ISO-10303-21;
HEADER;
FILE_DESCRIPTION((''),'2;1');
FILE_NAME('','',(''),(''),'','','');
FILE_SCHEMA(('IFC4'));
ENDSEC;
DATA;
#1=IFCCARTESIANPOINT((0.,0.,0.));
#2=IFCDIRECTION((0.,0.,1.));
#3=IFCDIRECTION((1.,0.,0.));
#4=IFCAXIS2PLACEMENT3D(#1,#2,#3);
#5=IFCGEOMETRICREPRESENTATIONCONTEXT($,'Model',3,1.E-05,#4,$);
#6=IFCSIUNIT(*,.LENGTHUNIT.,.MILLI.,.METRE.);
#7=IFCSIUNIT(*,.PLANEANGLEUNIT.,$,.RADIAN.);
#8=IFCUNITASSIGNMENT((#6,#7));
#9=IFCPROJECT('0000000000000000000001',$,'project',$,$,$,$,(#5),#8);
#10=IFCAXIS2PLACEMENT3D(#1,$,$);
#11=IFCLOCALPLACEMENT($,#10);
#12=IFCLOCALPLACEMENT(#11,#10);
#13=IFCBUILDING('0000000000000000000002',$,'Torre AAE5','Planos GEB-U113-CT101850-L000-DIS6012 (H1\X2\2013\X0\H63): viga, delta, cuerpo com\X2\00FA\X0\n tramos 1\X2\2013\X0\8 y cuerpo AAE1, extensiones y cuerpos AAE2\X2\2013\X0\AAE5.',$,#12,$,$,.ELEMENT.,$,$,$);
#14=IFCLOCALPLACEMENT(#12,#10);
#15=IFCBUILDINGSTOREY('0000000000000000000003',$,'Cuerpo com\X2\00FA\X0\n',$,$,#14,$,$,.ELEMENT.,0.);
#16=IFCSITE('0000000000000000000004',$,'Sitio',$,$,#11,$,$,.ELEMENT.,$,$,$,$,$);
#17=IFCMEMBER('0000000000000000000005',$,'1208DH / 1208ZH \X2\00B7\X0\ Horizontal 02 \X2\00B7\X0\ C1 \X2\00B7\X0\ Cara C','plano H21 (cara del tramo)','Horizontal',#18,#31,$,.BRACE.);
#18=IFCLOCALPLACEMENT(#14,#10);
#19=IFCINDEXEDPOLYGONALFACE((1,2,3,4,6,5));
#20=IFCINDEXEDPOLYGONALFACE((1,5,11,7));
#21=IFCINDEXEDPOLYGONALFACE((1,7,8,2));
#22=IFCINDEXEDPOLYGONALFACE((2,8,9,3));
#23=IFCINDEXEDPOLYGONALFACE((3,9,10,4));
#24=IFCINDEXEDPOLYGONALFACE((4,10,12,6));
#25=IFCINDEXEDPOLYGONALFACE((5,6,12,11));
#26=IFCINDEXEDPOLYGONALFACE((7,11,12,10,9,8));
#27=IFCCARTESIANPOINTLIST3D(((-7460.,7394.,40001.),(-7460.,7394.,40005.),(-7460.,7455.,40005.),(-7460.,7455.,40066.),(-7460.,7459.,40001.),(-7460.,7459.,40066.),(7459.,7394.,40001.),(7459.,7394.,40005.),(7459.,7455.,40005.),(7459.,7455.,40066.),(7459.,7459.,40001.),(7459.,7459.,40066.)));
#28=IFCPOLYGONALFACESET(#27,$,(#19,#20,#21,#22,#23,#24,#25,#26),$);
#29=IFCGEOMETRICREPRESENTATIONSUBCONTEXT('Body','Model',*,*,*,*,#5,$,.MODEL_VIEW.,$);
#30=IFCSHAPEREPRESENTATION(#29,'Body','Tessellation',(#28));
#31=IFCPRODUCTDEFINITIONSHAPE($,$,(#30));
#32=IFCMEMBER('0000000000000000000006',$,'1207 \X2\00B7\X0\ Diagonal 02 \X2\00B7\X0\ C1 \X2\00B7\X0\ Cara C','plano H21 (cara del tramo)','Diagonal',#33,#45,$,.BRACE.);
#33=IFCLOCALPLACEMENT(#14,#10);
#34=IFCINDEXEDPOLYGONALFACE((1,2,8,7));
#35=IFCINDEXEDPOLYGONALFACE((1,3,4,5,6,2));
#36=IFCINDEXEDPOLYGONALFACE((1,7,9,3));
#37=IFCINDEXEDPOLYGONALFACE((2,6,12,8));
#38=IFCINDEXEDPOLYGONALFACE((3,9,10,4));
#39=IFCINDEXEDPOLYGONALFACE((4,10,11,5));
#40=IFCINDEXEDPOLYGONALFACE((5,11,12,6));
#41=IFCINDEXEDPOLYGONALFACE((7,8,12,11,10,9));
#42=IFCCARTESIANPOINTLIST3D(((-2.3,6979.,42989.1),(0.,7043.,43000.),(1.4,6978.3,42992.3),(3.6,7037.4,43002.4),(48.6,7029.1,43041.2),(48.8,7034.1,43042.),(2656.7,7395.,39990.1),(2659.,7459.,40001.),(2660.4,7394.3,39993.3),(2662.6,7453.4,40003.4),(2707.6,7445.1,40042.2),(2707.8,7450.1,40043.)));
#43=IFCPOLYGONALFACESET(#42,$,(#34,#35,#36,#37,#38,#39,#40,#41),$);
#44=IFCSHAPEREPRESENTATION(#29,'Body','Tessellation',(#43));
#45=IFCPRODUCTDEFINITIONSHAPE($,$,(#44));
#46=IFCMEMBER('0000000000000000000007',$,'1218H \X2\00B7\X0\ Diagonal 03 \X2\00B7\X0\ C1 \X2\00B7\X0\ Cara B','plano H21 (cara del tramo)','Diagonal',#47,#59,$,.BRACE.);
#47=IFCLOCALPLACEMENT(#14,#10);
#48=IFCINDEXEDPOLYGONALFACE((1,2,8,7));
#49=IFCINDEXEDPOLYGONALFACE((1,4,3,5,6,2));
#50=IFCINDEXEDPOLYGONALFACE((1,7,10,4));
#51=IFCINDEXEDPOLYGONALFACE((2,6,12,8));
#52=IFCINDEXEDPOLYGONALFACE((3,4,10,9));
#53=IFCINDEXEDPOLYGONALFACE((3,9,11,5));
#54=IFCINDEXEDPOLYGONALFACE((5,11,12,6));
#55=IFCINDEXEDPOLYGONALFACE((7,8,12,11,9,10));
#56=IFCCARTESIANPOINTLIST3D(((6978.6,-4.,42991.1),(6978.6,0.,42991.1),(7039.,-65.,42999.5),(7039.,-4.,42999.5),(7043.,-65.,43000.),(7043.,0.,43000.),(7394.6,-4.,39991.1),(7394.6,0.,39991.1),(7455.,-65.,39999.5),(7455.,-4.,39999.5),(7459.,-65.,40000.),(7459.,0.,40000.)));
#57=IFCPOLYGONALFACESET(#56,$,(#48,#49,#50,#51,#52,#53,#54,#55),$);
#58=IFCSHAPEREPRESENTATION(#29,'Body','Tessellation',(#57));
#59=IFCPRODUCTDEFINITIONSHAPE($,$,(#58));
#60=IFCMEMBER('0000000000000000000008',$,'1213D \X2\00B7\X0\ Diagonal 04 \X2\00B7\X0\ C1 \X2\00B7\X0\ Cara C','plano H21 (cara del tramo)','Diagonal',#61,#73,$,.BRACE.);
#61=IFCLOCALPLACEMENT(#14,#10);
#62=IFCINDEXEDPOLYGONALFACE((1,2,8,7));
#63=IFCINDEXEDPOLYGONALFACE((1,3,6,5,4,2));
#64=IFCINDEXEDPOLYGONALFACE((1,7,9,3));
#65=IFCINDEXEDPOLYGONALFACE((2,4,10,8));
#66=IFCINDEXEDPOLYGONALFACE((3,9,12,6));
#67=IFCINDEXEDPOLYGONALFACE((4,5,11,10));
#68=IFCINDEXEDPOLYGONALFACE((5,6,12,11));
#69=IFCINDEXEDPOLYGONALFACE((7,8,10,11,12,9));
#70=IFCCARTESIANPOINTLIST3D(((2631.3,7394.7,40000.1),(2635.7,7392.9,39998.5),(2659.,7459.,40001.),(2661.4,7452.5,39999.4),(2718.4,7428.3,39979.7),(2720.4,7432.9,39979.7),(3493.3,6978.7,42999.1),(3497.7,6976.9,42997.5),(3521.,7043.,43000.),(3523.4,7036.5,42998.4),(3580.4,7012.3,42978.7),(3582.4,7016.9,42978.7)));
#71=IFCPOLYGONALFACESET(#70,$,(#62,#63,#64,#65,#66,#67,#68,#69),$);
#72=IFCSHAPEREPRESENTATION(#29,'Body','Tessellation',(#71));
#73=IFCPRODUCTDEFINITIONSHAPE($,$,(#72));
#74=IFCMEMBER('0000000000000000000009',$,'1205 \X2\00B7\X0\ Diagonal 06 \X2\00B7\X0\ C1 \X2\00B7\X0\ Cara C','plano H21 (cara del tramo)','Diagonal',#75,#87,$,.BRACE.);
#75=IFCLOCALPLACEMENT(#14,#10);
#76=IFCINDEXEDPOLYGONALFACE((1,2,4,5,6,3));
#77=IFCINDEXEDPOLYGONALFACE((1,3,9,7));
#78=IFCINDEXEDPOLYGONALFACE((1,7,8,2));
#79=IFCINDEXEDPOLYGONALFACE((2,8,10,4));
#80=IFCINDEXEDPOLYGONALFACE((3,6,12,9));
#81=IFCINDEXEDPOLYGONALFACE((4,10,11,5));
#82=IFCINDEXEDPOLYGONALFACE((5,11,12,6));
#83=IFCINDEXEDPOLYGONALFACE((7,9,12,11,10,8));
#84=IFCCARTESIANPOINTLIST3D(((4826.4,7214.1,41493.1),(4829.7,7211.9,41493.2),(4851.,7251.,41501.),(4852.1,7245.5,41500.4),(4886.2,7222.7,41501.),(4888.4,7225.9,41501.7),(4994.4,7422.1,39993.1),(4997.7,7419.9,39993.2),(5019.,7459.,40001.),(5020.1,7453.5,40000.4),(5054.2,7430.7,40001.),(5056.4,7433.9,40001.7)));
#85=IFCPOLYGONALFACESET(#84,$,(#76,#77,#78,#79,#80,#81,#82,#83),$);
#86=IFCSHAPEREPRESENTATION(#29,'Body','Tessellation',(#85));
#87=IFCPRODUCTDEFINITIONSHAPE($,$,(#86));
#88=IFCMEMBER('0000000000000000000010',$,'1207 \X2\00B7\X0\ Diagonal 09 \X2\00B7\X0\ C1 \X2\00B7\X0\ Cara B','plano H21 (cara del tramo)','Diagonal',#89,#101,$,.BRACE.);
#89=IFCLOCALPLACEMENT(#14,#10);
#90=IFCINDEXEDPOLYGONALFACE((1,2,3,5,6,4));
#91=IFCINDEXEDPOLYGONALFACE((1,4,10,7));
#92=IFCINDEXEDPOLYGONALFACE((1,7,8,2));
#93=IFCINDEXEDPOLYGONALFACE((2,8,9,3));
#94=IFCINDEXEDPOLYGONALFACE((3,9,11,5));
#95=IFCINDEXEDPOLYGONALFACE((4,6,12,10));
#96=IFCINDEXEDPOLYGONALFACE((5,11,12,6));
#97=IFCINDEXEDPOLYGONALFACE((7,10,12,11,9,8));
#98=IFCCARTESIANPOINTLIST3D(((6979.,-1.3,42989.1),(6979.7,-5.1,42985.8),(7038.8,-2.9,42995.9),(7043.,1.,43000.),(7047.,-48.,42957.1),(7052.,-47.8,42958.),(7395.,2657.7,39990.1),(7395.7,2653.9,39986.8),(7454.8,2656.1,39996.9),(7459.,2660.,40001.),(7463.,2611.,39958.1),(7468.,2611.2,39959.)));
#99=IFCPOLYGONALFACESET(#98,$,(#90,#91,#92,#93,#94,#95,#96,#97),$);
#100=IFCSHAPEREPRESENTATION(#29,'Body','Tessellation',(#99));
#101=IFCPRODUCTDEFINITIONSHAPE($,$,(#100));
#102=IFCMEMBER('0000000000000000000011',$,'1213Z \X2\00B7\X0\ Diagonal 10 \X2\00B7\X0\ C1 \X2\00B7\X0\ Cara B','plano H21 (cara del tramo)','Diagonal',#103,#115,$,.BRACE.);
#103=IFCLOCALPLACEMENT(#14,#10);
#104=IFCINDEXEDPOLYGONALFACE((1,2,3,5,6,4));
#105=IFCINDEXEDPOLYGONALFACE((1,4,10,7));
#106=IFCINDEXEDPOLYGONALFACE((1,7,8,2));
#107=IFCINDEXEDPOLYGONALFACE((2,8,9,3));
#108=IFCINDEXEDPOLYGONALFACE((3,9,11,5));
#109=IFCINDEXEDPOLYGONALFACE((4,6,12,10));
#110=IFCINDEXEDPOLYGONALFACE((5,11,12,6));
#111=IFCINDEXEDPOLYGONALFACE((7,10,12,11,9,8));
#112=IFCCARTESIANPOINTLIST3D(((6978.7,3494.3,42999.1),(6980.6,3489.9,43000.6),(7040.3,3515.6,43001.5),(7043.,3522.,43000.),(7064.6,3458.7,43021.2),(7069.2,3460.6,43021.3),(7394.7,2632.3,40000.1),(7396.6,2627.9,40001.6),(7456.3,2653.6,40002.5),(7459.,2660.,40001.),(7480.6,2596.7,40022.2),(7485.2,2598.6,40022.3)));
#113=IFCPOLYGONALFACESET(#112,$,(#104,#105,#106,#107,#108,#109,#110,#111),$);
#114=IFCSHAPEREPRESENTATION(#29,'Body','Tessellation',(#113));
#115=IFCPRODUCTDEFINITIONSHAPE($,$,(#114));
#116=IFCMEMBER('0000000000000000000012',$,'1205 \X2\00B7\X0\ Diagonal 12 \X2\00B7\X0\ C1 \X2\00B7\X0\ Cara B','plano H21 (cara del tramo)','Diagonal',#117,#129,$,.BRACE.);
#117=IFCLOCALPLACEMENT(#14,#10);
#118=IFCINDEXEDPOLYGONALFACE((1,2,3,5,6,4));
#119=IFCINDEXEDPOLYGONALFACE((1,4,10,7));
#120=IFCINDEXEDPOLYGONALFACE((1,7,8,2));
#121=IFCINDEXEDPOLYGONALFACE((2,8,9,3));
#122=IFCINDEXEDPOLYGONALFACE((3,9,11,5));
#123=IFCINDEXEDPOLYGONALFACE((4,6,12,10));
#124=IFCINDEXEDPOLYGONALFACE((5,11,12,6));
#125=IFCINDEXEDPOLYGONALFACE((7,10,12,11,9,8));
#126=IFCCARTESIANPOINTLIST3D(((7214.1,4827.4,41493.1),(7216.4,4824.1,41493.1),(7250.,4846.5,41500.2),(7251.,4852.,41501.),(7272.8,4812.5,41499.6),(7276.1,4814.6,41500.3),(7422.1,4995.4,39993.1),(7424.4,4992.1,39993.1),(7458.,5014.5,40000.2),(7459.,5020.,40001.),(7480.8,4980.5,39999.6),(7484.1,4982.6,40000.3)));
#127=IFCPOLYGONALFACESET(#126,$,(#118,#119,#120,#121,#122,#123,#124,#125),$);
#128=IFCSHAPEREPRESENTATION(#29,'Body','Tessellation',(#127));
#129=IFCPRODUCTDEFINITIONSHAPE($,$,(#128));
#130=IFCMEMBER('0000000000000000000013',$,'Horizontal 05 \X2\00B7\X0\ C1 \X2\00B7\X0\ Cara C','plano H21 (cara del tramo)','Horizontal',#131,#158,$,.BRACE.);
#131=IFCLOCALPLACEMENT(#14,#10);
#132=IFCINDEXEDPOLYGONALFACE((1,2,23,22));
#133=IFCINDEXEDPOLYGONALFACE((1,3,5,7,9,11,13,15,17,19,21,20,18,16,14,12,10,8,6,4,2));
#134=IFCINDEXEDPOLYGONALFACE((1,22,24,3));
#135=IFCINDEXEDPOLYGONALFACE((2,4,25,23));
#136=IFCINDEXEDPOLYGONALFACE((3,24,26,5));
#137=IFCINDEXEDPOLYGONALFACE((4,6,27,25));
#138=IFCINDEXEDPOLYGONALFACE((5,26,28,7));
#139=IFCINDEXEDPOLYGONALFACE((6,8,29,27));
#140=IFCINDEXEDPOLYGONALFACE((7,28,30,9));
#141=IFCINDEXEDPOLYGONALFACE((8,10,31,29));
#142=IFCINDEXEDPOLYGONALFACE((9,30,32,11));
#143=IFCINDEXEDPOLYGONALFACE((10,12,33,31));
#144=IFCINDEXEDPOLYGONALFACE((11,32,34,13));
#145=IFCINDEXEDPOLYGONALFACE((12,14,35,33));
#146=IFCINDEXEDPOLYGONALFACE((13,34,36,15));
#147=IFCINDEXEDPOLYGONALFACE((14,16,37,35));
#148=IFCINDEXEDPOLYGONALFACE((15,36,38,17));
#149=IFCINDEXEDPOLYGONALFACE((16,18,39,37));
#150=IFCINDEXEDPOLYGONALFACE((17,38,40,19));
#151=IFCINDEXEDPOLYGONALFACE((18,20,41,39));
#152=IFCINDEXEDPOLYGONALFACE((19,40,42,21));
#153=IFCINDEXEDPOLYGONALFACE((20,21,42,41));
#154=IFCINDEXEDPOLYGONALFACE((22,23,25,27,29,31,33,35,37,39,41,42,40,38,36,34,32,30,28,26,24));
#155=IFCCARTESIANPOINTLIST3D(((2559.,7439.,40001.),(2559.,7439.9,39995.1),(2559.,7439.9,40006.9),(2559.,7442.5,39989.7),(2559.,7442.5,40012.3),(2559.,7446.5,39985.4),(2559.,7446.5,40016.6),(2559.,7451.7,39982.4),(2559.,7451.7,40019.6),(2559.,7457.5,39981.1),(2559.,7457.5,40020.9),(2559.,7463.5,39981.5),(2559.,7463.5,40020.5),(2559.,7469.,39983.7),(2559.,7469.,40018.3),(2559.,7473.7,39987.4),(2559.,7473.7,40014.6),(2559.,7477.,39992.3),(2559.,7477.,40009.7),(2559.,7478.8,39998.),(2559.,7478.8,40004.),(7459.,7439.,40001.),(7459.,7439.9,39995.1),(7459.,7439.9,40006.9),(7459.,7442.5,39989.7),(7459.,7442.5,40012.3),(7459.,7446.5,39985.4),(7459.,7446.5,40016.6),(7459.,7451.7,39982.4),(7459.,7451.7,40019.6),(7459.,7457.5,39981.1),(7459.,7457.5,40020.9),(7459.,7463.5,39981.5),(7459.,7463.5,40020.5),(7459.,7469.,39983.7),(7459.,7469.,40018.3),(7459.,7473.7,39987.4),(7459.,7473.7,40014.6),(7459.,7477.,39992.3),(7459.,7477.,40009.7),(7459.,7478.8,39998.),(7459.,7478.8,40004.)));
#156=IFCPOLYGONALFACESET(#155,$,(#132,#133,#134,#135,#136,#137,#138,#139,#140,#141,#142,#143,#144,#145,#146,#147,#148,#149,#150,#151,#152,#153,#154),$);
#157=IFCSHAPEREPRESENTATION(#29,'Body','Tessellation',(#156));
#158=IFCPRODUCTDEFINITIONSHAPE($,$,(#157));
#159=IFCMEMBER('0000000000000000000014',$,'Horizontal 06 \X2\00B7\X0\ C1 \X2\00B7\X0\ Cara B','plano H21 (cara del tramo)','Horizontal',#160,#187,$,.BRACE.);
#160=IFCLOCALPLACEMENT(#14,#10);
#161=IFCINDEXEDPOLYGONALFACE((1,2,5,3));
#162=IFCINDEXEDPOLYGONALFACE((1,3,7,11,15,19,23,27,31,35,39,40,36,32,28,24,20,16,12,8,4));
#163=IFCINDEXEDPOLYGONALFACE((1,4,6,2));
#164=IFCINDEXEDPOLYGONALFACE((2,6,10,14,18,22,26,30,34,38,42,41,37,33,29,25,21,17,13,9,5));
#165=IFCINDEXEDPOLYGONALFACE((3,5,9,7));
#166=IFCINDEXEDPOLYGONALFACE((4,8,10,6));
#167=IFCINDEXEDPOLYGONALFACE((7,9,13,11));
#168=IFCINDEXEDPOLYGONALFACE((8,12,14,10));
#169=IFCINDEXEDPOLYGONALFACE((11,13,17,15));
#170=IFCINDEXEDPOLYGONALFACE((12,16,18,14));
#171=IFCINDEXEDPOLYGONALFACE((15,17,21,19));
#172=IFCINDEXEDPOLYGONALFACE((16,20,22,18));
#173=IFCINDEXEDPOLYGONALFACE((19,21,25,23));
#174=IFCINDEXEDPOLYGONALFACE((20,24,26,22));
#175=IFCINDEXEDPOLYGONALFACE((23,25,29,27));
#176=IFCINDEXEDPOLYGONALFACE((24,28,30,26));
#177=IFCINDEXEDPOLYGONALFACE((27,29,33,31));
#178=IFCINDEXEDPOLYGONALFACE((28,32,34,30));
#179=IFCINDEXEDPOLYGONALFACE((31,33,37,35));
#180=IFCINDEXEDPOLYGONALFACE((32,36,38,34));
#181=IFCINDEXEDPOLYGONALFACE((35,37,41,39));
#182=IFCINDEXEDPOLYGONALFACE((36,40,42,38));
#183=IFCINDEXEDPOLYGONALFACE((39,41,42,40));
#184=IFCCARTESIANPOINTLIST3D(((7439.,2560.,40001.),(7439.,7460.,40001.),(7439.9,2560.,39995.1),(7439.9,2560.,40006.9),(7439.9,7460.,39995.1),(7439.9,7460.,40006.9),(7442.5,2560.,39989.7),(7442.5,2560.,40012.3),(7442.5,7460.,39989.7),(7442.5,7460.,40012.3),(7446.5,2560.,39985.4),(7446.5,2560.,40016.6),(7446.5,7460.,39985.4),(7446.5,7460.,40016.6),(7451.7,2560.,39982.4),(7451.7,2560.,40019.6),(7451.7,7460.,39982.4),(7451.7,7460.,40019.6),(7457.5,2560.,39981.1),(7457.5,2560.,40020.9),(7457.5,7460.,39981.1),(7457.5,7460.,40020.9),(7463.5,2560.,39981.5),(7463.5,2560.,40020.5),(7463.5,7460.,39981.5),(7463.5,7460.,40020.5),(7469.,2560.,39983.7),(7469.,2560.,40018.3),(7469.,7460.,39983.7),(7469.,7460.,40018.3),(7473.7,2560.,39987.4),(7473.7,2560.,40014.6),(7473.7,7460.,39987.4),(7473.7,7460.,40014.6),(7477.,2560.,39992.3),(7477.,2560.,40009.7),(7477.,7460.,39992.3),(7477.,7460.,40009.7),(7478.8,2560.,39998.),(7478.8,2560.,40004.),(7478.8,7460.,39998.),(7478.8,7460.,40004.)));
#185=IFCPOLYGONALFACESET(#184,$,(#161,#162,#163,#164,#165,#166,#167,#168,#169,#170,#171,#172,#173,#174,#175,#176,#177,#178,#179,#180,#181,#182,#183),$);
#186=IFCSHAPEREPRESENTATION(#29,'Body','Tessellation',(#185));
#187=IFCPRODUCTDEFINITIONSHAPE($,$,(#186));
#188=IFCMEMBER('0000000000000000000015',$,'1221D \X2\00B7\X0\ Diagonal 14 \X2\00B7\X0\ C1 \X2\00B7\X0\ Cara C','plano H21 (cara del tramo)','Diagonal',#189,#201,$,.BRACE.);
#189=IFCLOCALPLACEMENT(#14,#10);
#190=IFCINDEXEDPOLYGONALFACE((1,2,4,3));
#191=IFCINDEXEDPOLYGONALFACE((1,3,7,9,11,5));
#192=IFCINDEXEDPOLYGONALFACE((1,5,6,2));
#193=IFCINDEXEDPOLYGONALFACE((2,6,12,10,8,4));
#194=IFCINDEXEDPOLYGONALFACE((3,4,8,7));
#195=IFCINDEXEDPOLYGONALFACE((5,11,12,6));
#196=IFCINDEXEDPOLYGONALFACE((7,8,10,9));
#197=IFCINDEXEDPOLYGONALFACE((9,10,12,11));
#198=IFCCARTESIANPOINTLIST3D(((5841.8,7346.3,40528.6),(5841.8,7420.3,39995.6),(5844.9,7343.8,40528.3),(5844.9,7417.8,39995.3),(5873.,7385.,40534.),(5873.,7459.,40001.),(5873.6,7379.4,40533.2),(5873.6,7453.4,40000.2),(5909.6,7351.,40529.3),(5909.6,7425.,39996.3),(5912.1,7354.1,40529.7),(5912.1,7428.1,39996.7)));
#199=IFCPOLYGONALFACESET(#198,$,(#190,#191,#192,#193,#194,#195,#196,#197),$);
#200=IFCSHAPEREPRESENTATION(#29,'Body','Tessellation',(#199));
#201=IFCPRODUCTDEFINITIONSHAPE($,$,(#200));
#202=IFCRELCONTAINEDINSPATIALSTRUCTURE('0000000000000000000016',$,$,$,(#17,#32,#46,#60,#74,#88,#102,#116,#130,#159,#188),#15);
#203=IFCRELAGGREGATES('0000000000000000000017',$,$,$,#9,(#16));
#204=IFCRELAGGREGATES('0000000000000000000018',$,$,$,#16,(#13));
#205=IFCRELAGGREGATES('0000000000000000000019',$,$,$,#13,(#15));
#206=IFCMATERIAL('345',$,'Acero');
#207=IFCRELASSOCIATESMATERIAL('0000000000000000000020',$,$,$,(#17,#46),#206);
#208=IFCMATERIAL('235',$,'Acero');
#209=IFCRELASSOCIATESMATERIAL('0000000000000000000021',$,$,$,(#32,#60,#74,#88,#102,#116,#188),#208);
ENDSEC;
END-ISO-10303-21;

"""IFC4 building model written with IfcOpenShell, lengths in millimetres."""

from ifc_helpers import new_model, si_unit, frame, frame_2d, origin, origin_with_axes, place, context, subcontext, project, spatial, circle, l_section, extrude, material, element, save


model = new_model("IFC4")

# Units and contexts
model_context = context("Model", 3, precision=1e-05, world=origin_with_axes())
body_context = subcontext(model_context, "Body", "Model", "MODEL_VIEW")
ifc_project = project(units=[si_unit("LENGTHUNIT", "METRE", prefix="MILLI"), si_unit("PLANEANGLEUNIT", "RADIAN")], contexts=[model_context])

# Site, building, storey
site_placement = place(None, origin())
site = spatial("IfcSite", under=ifc_project, at=site_placement, Name="Sitio", CompositionType="ELEMENT")
building_placement = place(site_placement, origin())
building = spatial("IfcBuilding", under=site, at=building_placement, Name="Torre AAE5", Description="Planos GEB-U113-CT101850-L000-DIS6012 (H1–H63): viga, delta, cuerpo común tramos 1–8 y cuerpo AAE1, extensiones y cuerpos AAE2–AAE5.", CompositionType="ELEMENT")
storey_placement = place(building_placement, origin())
storey = spatial("IfcBuildingStorey", under=building, at=storey_placement, Name="Cuerpo común", CompositionType="ELEMENT", Elevation=0.0)

# Members
ifc_material_1 = material(Name="345", Category="Acero")
member_1_placement = place(storey_placement, frame((7459.0, 7459.0, 40001.0), z_axis=(-1.0, 0.0, 0.0), x_axis=(0.0, -1.0, 0.0)))
element("IfcMember", 1, at=member_1_placement, inside=storey, material=ifc_material_1, Name="1208DH / 1208ZH · Horizontal 02 · C1 · Cara C", Description="plano H21 (cara del tramo)", ObjectType="Horizontal", PredefinedType="BRACE", context=body_context, shape_type="SweptSolid", body=[
    extrude(l_section(Depth=65.0, Width=65.0, Thickness=4.0, at=frame_2d((32.5, 32.5))), None, (0.0, 0.0, 1.0), 14919.0),
])
ifc_material_2 = material(Name="235", Category="Acero")
member_2_placement = place(storey_placement, frame((2659.0, 7459.0, 40001.0), z_axis=(-0.659874, -0.103237, 0.74425), x_axis=(-0.035691, -0.985091, -0.168289)))
element("IfcMember", 2, at=member_2_placement, inside=storey, material=ifc_material_2, Name="1207 · Diagonal 02 · C1 · Cara C", Description="plano H21 (cara del tramo)", ObjectType="Diagonal", PredefinedType="BRACE", context=body_context, shape_type="SweptSolid", body=[
    extrude(l_section(Depth=65.0, Width=65.0, Thickness=5.0, at=frame_2d((32.5, 32.5))), None, (0.0, 0.0, 1.0), 4029.6),
])
member_3_placement = place(storey_placement, frame((7459.0, 0.0, 40000.0), z_axis=(-0.137352, 0.0, 0.990522), x_axis=(-0.990522, 0.0, -0.137352)))
element("IfcMember", 3, at=member_3_placement, inside=storey, material=ifc_material_1, Name="1218H · Diagonal 03 · C1 · Cara B", Description="plano H21 (cara del tramo)", ObjectType="Diagonal", PredefinedType="BRACE", context=body_context, shape_type="SweptSolid", body=[
    extrude(l_section(Depth=65.0, Width=65.0, Thickness=4.0, at=frame_2d((32.5, 32.5))), None, (0.0, 0.0, 1.0), 3028.7),
])
member_4_placement = place(storey_placement, frame((2659.0, 7459.0, 40001.0), z_axis=(0.273822, -0.132146, 0.952659), x_axis=(-0.395969, -0.918164, -0.013548)))
element("IfcMember", 4, at=member_4_placement, inside=storey, material=ifc_material_2, Name="1213D · Diagonal 04 · C1 · Cara C", Description="plano H21 (cara del tramo)", ObjectType="Diagonal", PredefinedType="BRACE", context=body_context, shape_type="SweptSolid", body=[
    extrude(l_section(Depth=70.0, Width=70.0, Thickness=5.0, at=frame_2d((35.0, 35.0))), None, (0.0, 0.0, 1.0), 3148.0),
])
member_5_placement = place(storey_placement, frame((5019.0, 7459.0, 40001.0), z_axis=(-0.110262, -0.136515, 0.984483), x_axis=(-0.54631, -0.819145, -0.174775)))
element("IfcMember", 5, at=member_5_placement, inside=storey, material=ifc_material_2, Name="1205 · Diagonal 06 · C1 · Cara C", Description="plano H21 (cara del tramo)", ObjectType="Diagonal", PredefinedType="BRACE", context=body_context, shape_type="SweptSolid", body=[
    extrude(l_section(Depth=45.0, Width=45.0, Thickness=4.0, at=frame_2d((22.5, 22.5))), None, (0.0, 0.0, 1.0), 1523.6),
])
member_6_placement = place(storey_placement, frame((7459.0, 2660.0, 40001.0), z_axis=(-0.103237, -0.659874, 0.74425), x_axis=(-0.985077, -0.035769, -0.168357)))
element("IfcMember", 6, at=member_6_placement, inside=storey, material=ifc_material_2, Name="1207 · Diagonal 09 · C1 · Cara B", Description="plano H21 (cara del tramo)", ObjectType="Diagonal", PredefinedType="BRACE", context=body_context, shape_type="SweptSolid", body=[
    extrude(l_section(Depth=65.0, Width=65.0, Thickness=5.0, at=frame_2d((32.5, 32.5))), None, (0.0, 0.0, 1.0), 4029.6),
])
member_7_placement = place(storey_placement, frame((7459.0, 2660.0, 40001.0), z_axis=(-0.132146, 0.273822, 0.952659), x_axis=(-0.918122, -0.396066, -0.013514)))
element("IfcMember", 7, at=member_7_placement, inside=storey, material=ifc_material_2, Name="1213Z · Diagonal 10 · C1 · Cara B", Description="plano H21 (cara del tramo)", ObjectType="Diagonal", PredefinedType="BRACE", context=body_context, shape_type="SweptSolid", body=[
    extrude(l_section(Depth=70.0, Width=70.0, Thickness=5.0, at=frame_2d((35.0, 35.0))), None, (0.0, 0.0, 1.0), 3148.0),
])
member_8_placement = place(storey_placement, frame((7459.0, 5020.0, 40001.0), z_axis=(-0.136515, -0.110262, 0.984483), x_axis=(-0.819092, -0.546389, -0.174776)))
element("IfcMember", 8, at=member_8_placement, inside=storey, material=ifc_material_2, Name="1205 · Diagonal 12 · C1 · Cara B", Description="plano H21 (cara del tramo)", ObjectType="Diagonal", PredefinedType="BRACE", context=body_context, shape_type="SweptSolid", body=[
    extrude(l_section(Depth=45.0, Width=45.0, Thickness=4.0, at=frame_2d((22.5, 22.5))), None, (0.0, 0.0, 1.0), 1523.6),
])
for number, where, z_axis, x_axis, name in (
    (9, (7459.0, 7459.0, 40001.0), (-1.0, 0.0, 0.0), (0.0, -1.0, 0.0), "Horizontal 05 · C1 · Cara C"),
    (10, (7459.0, 7460.0, 40001.0), (0.0, -1.0, 0.0), (-1.0, 0.0, 0.0), "Horizontal 06 · C1 · Cara B"),
):
    element("IfcMember", number, at=place(storey_placement, frame(where, z_axis=z_axis, x_axis=x_axis)), inside=storey, Name=name, Description="plano H21 (cara del tramo)", ObjectType="Horizontal", PredefinedType="BRACE", context=body_context, shape_type="SweptSolid", body=[
        extrude(circle(Radius=20.0), None, (0.0, 0.0, 1.0), 4900.0),
    ])
for number, where, z_axis, x_axis, name in (
    (11, (5873.0, 7459.0, 40001.0), (0.0, -0.137518, 0.990499), (-0.624164, -0.77387, -0.107442), "1221D · Diagonal 14 · C1 · Cara C"),
):
    element("IfcMember", number, at=place(storey_placement, frame(where, z_axis=z_axis, x_axis=x_axis)), inside=storey, material=ifc_material_2, Name=name, Description="plano H21 (cara del tramo)", ObjectType="Diagonal", PredefinedType="BRACE", context=body_context, shape_type="SweptSolid", body=[
        extrude(l_section(Depth=50.0, Width=50.0, Thickness=4.0, at=frame_2d((25.0, 25.0))), None, (0.0, 0.0, 1.0), 538.1),
    ])

save(model, "model.ifc")
